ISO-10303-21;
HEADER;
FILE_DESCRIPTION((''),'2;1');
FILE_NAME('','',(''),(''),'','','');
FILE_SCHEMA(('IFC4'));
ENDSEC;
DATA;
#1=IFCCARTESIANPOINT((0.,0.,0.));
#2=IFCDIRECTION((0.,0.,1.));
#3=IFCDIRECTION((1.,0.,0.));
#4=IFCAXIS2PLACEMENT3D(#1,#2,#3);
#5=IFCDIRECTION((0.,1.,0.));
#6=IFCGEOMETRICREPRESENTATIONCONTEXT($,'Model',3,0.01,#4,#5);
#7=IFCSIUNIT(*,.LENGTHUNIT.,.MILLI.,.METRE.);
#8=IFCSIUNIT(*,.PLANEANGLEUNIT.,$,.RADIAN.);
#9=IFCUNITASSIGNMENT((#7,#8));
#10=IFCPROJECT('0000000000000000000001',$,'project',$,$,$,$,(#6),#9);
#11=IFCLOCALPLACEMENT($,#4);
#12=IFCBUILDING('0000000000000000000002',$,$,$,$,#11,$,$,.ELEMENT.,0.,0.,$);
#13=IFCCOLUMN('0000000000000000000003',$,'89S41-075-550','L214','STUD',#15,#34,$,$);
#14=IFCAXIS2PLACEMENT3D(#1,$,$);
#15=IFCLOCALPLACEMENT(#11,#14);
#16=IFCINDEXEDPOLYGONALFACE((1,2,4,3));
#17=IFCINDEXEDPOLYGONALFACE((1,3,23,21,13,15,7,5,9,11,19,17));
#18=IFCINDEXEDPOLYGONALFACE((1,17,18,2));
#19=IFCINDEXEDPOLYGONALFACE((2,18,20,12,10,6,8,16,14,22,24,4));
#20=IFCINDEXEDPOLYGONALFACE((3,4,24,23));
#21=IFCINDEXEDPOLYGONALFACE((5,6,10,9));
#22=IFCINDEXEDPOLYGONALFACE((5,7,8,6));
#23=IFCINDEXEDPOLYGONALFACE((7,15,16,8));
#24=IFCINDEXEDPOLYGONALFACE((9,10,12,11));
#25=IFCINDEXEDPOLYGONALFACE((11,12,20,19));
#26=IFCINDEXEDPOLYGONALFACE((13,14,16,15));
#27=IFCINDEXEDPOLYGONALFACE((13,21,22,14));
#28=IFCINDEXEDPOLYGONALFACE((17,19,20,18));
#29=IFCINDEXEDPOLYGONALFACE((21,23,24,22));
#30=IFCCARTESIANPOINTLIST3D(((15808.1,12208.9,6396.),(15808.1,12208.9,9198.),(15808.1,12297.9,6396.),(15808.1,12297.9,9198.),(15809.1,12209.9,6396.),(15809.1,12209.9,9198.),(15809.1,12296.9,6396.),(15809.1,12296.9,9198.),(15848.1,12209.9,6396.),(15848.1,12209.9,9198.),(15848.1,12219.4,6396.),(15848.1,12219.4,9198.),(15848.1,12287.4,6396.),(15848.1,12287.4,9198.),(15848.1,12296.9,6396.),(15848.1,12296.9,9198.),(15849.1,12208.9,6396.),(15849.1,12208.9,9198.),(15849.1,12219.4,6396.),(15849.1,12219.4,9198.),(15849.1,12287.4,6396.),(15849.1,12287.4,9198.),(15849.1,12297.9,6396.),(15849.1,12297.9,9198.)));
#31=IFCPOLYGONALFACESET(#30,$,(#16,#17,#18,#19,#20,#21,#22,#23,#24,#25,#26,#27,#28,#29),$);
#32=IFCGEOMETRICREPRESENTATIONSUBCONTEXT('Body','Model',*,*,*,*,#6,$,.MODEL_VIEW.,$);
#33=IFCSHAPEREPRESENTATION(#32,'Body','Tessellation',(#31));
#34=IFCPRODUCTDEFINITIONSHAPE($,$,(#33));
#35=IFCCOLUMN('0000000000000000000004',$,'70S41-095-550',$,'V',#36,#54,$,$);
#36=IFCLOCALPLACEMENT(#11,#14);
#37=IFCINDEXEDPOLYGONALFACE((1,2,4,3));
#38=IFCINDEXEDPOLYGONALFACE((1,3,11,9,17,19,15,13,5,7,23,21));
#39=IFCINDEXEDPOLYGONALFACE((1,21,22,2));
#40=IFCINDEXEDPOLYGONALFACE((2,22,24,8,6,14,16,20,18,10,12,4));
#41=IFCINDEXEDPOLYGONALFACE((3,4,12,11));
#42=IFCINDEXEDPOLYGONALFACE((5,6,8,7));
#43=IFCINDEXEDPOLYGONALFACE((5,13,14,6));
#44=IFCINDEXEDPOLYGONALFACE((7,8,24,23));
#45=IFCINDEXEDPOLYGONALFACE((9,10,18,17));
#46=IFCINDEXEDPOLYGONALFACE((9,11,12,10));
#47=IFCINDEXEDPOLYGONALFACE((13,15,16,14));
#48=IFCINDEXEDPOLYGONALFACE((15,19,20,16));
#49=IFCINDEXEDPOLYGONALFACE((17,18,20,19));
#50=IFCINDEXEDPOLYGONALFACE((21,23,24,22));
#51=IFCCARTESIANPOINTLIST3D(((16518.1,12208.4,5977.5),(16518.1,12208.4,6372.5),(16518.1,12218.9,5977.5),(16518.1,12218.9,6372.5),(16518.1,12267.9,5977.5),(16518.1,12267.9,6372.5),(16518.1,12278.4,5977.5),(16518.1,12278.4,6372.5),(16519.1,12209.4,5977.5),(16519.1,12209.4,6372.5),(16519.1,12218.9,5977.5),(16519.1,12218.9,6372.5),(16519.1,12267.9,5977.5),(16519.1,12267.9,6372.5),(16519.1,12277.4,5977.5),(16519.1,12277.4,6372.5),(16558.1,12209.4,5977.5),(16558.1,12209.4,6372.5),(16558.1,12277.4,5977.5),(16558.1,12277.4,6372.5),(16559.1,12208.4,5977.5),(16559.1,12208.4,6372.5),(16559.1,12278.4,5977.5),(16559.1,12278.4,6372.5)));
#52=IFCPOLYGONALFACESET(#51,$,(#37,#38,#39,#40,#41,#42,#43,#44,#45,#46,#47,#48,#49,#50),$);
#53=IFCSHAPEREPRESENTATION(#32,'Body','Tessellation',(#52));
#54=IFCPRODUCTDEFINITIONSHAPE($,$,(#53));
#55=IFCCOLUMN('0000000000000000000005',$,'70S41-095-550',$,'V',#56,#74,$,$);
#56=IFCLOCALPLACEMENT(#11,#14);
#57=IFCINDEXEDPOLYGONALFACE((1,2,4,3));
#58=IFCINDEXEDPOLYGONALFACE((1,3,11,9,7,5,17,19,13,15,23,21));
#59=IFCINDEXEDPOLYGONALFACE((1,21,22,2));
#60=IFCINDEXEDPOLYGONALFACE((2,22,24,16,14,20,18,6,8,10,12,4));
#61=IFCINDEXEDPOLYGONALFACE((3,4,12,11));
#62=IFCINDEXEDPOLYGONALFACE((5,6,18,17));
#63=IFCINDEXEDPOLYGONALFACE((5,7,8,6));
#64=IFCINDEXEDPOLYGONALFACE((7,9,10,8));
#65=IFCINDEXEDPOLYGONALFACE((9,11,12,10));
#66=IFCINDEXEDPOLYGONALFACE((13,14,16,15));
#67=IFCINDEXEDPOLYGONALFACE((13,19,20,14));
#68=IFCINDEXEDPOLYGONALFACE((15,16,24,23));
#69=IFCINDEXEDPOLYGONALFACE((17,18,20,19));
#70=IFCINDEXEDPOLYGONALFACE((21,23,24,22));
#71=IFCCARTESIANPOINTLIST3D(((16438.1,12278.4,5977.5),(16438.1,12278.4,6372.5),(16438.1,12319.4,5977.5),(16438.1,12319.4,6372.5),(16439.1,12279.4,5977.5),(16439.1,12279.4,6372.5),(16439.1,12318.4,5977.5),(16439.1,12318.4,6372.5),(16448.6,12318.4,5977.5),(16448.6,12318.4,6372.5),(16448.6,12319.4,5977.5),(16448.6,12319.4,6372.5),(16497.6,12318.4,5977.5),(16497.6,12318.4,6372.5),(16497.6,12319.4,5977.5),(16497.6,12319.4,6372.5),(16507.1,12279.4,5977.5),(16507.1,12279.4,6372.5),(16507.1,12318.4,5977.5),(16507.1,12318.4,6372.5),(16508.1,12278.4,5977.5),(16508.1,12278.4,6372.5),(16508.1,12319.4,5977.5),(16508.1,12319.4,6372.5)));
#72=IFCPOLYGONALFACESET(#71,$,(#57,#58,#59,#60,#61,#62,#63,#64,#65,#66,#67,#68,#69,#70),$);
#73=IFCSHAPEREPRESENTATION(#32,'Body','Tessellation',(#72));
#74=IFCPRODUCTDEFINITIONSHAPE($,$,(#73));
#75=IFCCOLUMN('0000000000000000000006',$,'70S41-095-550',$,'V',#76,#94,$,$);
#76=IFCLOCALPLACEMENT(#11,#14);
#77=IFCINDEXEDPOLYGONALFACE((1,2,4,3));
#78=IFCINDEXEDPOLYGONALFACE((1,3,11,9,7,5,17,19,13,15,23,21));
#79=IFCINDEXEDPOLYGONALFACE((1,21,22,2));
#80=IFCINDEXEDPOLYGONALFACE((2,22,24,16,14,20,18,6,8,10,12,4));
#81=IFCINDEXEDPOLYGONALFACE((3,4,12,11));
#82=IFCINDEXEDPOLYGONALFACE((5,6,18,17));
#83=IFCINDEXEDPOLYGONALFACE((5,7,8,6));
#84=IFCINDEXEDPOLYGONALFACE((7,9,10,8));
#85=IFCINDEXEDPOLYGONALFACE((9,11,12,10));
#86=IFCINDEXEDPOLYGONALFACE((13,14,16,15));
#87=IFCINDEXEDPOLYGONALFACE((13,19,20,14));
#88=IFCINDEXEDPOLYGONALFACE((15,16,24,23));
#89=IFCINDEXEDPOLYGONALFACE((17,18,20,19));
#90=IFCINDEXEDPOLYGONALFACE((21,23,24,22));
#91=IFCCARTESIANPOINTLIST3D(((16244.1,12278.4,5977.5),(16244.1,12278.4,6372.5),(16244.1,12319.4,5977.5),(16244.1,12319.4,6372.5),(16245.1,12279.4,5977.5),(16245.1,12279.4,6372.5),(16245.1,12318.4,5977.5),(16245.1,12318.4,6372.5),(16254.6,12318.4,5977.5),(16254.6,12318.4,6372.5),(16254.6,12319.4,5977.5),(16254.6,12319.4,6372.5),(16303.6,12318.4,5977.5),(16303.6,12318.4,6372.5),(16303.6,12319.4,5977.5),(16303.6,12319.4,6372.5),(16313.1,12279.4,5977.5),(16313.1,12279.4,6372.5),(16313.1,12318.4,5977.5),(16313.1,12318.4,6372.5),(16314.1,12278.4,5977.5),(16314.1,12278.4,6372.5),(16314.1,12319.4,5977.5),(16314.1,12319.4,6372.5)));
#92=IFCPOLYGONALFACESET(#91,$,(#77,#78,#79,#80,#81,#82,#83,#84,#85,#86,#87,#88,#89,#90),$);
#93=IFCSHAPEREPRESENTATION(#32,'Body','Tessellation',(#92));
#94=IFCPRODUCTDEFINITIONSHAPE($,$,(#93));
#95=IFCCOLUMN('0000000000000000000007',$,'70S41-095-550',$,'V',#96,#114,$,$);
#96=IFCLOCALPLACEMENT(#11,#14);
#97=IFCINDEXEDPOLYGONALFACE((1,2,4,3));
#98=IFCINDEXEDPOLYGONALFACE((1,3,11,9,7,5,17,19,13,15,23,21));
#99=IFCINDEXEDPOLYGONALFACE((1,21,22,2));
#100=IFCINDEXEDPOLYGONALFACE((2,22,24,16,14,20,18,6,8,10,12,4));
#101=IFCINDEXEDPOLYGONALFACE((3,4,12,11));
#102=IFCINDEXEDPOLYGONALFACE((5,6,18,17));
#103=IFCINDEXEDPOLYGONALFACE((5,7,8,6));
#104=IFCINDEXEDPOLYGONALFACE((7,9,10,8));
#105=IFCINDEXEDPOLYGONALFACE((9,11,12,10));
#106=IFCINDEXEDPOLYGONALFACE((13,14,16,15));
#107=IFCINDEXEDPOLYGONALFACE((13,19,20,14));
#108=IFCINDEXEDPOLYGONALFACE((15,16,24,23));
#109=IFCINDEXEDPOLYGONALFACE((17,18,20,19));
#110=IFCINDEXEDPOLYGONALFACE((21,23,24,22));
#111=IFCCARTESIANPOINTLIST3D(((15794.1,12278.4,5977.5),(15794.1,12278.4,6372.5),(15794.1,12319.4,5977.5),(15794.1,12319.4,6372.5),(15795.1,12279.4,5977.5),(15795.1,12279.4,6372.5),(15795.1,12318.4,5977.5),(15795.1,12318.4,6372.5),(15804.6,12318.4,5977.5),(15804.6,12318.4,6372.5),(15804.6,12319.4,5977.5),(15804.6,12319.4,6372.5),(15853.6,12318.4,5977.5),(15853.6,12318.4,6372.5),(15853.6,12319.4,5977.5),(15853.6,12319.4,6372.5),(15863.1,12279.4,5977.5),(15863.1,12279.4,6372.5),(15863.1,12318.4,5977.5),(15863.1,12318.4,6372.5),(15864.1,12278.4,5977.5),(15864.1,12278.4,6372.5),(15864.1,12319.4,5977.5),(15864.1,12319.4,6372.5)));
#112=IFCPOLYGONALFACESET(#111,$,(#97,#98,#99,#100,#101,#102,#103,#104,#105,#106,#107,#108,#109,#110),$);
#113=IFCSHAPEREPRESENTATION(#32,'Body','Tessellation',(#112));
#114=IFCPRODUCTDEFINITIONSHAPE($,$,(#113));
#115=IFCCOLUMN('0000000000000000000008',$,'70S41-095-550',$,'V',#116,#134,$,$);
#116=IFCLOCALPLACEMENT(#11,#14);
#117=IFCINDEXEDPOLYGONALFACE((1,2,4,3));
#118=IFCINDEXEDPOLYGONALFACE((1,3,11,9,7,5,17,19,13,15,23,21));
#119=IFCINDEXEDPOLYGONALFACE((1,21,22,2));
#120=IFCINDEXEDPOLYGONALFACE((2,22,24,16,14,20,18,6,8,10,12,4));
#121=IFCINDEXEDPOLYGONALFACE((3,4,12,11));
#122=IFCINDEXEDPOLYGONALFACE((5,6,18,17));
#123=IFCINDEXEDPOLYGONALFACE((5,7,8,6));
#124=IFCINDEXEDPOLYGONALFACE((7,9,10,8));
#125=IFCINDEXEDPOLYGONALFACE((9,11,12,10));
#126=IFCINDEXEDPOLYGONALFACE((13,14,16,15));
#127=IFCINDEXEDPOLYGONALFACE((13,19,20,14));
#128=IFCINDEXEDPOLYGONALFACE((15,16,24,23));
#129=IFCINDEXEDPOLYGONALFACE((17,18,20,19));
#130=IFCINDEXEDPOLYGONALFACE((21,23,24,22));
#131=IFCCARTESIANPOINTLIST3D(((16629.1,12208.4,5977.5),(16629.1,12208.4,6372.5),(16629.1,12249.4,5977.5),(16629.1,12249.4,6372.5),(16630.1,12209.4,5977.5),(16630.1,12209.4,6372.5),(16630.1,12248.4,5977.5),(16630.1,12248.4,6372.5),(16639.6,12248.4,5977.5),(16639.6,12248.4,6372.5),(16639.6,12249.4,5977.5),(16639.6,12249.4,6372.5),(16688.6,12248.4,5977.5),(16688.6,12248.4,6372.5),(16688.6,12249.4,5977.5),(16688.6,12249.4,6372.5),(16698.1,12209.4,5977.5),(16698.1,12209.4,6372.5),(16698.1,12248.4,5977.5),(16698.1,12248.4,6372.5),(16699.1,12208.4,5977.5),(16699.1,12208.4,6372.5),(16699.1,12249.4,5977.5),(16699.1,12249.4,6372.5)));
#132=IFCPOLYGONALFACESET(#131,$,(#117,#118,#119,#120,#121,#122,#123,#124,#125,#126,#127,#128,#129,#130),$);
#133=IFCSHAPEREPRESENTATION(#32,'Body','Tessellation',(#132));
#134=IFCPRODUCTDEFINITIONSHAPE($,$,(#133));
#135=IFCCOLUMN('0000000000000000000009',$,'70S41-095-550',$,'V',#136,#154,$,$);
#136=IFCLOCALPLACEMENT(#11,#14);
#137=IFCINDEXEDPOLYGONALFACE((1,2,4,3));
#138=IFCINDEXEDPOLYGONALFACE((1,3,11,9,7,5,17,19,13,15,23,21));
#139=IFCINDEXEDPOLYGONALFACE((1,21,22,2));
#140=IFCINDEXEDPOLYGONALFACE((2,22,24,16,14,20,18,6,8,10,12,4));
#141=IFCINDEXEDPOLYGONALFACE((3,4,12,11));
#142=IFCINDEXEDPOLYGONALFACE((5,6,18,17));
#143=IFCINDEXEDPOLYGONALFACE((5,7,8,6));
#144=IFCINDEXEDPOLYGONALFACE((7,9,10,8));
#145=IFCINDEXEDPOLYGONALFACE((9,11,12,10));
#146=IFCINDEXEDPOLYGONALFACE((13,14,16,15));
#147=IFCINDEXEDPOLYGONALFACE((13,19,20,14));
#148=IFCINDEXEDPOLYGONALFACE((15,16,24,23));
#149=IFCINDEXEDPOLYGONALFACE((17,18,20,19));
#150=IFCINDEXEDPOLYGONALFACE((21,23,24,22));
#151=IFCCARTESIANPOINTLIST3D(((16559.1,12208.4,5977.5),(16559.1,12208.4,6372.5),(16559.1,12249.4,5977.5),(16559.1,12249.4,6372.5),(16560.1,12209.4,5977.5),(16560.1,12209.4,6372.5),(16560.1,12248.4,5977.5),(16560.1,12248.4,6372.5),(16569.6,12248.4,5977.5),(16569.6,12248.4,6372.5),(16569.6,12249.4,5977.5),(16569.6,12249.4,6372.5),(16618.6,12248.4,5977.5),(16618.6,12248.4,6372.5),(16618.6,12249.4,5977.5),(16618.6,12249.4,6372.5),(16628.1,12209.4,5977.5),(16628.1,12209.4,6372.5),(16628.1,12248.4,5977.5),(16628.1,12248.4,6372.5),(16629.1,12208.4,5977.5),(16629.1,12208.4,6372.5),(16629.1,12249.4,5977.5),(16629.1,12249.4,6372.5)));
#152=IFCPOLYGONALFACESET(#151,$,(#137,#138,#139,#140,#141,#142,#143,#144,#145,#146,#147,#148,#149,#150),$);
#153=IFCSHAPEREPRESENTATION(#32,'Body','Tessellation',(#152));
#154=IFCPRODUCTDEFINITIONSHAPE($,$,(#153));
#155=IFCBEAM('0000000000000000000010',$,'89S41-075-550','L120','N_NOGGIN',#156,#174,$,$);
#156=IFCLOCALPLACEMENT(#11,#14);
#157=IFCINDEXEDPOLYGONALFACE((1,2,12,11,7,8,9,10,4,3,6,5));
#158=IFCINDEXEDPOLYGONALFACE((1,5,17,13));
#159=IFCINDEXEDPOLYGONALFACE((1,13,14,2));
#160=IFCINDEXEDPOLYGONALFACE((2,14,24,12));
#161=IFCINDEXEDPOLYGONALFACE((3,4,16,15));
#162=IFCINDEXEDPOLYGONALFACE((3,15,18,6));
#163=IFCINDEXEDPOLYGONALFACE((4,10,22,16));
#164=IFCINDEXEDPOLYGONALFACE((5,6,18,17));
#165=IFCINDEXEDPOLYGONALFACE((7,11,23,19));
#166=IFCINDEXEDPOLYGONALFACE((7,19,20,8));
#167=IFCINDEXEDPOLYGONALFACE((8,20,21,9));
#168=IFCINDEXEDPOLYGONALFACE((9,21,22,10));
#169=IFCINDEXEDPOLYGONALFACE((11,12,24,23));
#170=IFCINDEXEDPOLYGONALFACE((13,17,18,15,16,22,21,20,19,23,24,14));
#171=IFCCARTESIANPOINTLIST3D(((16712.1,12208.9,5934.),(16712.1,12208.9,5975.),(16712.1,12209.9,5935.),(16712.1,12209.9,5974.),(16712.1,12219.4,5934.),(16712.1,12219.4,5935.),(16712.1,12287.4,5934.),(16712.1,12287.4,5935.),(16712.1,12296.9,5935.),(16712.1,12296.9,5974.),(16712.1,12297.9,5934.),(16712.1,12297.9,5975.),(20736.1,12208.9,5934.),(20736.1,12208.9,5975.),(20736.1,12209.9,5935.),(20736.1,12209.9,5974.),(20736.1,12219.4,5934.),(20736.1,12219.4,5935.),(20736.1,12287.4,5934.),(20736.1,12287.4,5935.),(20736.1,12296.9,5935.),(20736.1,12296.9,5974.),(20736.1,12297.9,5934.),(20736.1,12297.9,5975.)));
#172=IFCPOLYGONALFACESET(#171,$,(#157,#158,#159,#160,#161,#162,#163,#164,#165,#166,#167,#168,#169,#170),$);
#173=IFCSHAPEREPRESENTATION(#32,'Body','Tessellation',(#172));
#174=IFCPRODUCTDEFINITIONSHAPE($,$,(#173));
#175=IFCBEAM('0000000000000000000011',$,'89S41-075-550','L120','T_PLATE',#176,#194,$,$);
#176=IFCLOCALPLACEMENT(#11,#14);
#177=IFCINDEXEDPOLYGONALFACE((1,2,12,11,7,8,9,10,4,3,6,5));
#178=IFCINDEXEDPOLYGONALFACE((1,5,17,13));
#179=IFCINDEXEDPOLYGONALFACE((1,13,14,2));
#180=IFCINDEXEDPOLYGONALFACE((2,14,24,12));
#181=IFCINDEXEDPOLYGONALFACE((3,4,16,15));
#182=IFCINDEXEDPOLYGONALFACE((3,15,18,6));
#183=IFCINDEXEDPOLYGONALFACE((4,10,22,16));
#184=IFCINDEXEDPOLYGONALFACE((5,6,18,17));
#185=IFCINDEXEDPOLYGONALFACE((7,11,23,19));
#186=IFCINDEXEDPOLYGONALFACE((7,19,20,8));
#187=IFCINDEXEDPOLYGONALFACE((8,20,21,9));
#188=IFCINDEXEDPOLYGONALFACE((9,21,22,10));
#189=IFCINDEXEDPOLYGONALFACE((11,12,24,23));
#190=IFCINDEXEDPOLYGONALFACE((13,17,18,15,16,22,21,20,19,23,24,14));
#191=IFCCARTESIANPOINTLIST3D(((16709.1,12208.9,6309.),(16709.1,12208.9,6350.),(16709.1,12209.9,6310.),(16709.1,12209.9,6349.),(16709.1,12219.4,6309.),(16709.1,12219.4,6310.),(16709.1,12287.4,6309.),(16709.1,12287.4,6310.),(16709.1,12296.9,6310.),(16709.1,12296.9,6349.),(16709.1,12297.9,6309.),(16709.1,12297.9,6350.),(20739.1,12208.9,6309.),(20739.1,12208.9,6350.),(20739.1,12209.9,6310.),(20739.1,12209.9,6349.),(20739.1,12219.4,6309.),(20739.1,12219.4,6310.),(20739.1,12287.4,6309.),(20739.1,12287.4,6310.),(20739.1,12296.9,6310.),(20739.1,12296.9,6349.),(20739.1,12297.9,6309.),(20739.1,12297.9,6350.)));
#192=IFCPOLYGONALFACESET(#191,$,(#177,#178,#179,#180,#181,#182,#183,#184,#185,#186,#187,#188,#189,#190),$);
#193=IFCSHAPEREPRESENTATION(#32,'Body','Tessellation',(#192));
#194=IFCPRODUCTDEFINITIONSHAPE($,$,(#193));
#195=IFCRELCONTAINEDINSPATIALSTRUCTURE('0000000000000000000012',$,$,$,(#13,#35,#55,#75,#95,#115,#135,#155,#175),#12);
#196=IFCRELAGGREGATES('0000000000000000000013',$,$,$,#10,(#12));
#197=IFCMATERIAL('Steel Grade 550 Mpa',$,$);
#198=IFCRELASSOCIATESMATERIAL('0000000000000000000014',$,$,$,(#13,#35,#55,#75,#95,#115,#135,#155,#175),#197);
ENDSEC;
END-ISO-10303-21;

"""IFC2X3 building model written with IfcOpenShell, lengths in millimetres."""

from ifc_helpers import new_model, si_unit, direction, frame, origin, origin_with_axes, origin_2d_with_axis, place, context, subcontext, project, spatial, c_section, extrude, source, transform, mapped, material, element, save


model = new_model("IFC2X3")

# Units and contexts
model_context = context("Model", 3, precision=0.01, world=origin_with_axes(), true_north=direction((0.0, 1.0, 0.0)))
body_context = subcontext(model_context, "Body", "Model", "MODEL_VIEW")
ifc_project = project(units=[si_unit("LENGTHUNIT", "METRE", prefix="MILLI"), si_unit("PLANEANGLEUNIT", "RADIAN")], contexts=[model_context])

# Building
building_placement = place(None, origin_with_axes())
building = spatial("IfcBuilding", under=ifc_project, at=building_placement, CompositionType="ELEMENT", ElevationOfRefHeight=0.0, ElevationOfTerrain=0.0)

# Columns
ifc_material = material(Name="Steel Grade 550 Mpa")
shared_shape_1 = source(origin(), body_context, "Body", "SweptSolid", [
    extrude(c_section(Depth=89.0, Width=41.0, WallThickness=1.0, Girth=10.5, at=origin_2d_with_axis()), origin_with_axes(), (0.0, 0.0, 1.0), 2802.0),
])
column_1_placement = place(None, frame((15828.6, 12253.4, 6396.0), z_axis=(0.0, 0.0, 1.0), x_axis=(1.0, 0.0, 0.0)))
element("IfcColumn", 1, at=column_1_placement, inside=building, material=ifc_material, Name="89S41-075-550", Description="L214", ObjectType="STUD", context=body_context, shape_type="MappedRepresentation", body=[
    mapped(shared_shape_1, transform((0.0, 0.0, 0.0), scale=1.0)),
])
shared_shape_2 = source(origin(), body_context, "Body", "SweptSolid", [
    extrude(c_section(Depth=70.0, Width=41.0, WallThickness=1.0, Girth=10.5, at=origin_2d_with_axis()), origin_with_axes(), (0.0, 0.0, 1.0), 395.0),
])
column_2_placement = place(None, frame((16538.6, 12243.4, 5977.5), z_axis=(0.0, 0.0, 1.0), x_axis=(-1.0, 0.0, 0.0)))
element("IfcColumn", 2, at=column_2_placement, inside=building, material=ifc_material, Name="70S41-095-550", ObjectType="V", context=body_context, shape_type="MappedRepresentation", body=[
    mapped(shared_shape_2, transform((0.0, 0.0, 0.0), scale=1.0)),
])
shared_shape_3 = source(origin(), body_context, "Body", "SweptSolid", [
    extrude(c_section(Depth=70.0, Width=41.0, WallThickness=1.0, Girth=10.5, at=origin_2d_with_axis()), origin_with_axes(), (0.0, 0.0, 1.0), 395.0),
])
column_3_placement = place(None, frame((16473.1, 12298.9, 6372.5), z_axis=(0.0, 0.0, -1.0), x_axis=(0.0, 1.0, 0.0)))
element("IfcColumn", 3, at=column_3_placement, inside=building, material=ifc_material, Name="70S41-095-550", ObjectType="V", context=body_context, shape_type="MappedRepresentation", body=[
    mapped(shared_shape_3, transform((0.0, 0.0, 0.0), scale=1.0)),
])
shared_shape_4 = source(origin(), body_context, "Body", "SweptSolid", [
    extrude(c_section(Depth=70.0, Width=41.0, WallThickness=1.0, Girth=10.5, at=origin_2d_with_axis()), origin_with_axes(), (0.0, 0.0, 1.0), 395.0),
])
column_4_placement = place(None, frame((16279.1, 12298.9, 6372.5), z_axis=(0.0, 0.0, -1.0), x_axis=(0.0, 1.0, 0.0)))
element("IfcColumn", 4, at=column_4_placement, inside=building, material=ifc_material, Name="70S41-095-550", ObjectType="V", context=body_context, shape_type="MappedRepresentation", body=[
    mapped(shared_shape_4, transform((0.0, 0.0, 0.0), scale=1.0)),
])
shared_shape_5 = source(origin(), body_context, "Body", "SweptSolid", [
    extrude(c_section(Depth=70.0, Width=41.0, WallThickness=1.0, Girth=10.5, at=origin_2d_with_axis()), origin_with_axes(), (0.0, 0.0, 1.0), 395.0),
])
column_5_placement = place(None, frame((15829.1, 12298.9, 6372.5), z_axis=(0.0, 0.0, -1.0), x_axis=(0.0, 1.0, 0.0)))
element("IfcColumn", 5, at=column_5_placement, inside=building, material=ifc_material, Name="70S41-095-550", ObjectType="V", context=body_context, shape_type="MappedRepresentation", body=[
    mapped(shared_shape_5, transform((0.0, 0.0, 0.0), scale=1.0)),
])
shared_shape_6 = source(origin(), body_context, "Body", "SweptSolid", [
    extrude(c_section(Depth=70.0, Width=41.0, WallThickness=1.0, Girth=10.5, at=origin_2d_with_axis()), origin_with_axes(), (0.0, 0.0, 1.0), 395.0),
])
column_6_placement = place(None, frame((16664.1, 12228.9, 5977.5), z_axis=(0.0, 0.0, 1.0), x_axis=(0.0, 1.0, 0.0)))
element("IfcColumn", 6, at=column_6_placement, inside=building, material=ifc_material, Name="70S41-095-550", ObjectType="V", context=body_context, shape_type="MappedRepresentation", body=[
    mapped(shared_shape_6, transform((0.0, 0.0, 0.0), scale=1.0)),
])
shared_shape_7 = source(origin(), body_context, "Body", "SweptSolid", [
    extrude(c_section(Depth=70.0, Width=41.0, WallThickness=1.0, Girth=10.5, at=origin_2d_with_axis()), origin_with_axes(), (0.0, 0.0, 1.0), 395.0),
])
column_7_placement = place(None, frame((16594.1, 12228.9, 6372.5), z_axis=(0.0, 0.0, -1.0), x_axis=(0.0, 1.0, 0.0)))
element("IfcColumn", 7, at=column_7_placement, inside=building, material=ifc_material, Name="70S41-095-550", ObjectType="V", context=body_context, shape_type="MappedRepresentation", body=[
    mapped(shared_shape_7, transform((0.0, 0.0, 0.0), scale=1.0)),
])

# Beams
shared_shape_8 = source(origin(), body_context, "Body", "SweptSolid", [
    extrude(c_section(Depth=89.0, Width=41.0, WallThickness=1.0, Girth=10.5, at=origin_2d_with_axis()), origin_with_axes(), (0.0, 0.0, 1.0), 4024.0),
])
beam_1_placement = place(None, frame((16712.1, 12253.4, 5954.5), z_axis=(1.0, 0.0, 0.0), x_axis=(0.0, 0.0, -1.0)))
element("IfcBeam", 8, at=beam_1_placement, inside=building, material=ifc_material, Name="89S41-075-550", Description="L120", ObjectType="N_NOGGIN", context=body_context, shape_type="MappedRepresentation", body=[
    mapped(shared_shape_8, transform((0.0, 0.0, 0.0), scale=1.0)),
])
shared_shape_9 = source(origin(), body_context, "Body", "SweptSolid", [
    extrude(c_section(Depth=89.0, Width=41.0, WallThickness=1.0, Girth=10.5, at=origin_2d_with_axis()), origin_with_axes(), (0.0, 0.0, 1.0), 4030.0),
])
beam_2_placement = place(None, frame((16709.1, 12253.4, 6329.5), z_axis=(1.0, 0.0, 0.0), x_axis=(0.0, 0.0, -1.0)))
element("IfcBeam", 9, at=beam_2_placement, inside=building, material=ifc_material, Name="89S41-075-550", Description="L120", ObjectType="T_PLATE", context=body_context, shape_type="MappedRepresentation", body=[
    mapped(shared_shape_9, transform((0.0, 0.0, 0.0), scale=1.0)),
])

save(model, "model.ifc")
